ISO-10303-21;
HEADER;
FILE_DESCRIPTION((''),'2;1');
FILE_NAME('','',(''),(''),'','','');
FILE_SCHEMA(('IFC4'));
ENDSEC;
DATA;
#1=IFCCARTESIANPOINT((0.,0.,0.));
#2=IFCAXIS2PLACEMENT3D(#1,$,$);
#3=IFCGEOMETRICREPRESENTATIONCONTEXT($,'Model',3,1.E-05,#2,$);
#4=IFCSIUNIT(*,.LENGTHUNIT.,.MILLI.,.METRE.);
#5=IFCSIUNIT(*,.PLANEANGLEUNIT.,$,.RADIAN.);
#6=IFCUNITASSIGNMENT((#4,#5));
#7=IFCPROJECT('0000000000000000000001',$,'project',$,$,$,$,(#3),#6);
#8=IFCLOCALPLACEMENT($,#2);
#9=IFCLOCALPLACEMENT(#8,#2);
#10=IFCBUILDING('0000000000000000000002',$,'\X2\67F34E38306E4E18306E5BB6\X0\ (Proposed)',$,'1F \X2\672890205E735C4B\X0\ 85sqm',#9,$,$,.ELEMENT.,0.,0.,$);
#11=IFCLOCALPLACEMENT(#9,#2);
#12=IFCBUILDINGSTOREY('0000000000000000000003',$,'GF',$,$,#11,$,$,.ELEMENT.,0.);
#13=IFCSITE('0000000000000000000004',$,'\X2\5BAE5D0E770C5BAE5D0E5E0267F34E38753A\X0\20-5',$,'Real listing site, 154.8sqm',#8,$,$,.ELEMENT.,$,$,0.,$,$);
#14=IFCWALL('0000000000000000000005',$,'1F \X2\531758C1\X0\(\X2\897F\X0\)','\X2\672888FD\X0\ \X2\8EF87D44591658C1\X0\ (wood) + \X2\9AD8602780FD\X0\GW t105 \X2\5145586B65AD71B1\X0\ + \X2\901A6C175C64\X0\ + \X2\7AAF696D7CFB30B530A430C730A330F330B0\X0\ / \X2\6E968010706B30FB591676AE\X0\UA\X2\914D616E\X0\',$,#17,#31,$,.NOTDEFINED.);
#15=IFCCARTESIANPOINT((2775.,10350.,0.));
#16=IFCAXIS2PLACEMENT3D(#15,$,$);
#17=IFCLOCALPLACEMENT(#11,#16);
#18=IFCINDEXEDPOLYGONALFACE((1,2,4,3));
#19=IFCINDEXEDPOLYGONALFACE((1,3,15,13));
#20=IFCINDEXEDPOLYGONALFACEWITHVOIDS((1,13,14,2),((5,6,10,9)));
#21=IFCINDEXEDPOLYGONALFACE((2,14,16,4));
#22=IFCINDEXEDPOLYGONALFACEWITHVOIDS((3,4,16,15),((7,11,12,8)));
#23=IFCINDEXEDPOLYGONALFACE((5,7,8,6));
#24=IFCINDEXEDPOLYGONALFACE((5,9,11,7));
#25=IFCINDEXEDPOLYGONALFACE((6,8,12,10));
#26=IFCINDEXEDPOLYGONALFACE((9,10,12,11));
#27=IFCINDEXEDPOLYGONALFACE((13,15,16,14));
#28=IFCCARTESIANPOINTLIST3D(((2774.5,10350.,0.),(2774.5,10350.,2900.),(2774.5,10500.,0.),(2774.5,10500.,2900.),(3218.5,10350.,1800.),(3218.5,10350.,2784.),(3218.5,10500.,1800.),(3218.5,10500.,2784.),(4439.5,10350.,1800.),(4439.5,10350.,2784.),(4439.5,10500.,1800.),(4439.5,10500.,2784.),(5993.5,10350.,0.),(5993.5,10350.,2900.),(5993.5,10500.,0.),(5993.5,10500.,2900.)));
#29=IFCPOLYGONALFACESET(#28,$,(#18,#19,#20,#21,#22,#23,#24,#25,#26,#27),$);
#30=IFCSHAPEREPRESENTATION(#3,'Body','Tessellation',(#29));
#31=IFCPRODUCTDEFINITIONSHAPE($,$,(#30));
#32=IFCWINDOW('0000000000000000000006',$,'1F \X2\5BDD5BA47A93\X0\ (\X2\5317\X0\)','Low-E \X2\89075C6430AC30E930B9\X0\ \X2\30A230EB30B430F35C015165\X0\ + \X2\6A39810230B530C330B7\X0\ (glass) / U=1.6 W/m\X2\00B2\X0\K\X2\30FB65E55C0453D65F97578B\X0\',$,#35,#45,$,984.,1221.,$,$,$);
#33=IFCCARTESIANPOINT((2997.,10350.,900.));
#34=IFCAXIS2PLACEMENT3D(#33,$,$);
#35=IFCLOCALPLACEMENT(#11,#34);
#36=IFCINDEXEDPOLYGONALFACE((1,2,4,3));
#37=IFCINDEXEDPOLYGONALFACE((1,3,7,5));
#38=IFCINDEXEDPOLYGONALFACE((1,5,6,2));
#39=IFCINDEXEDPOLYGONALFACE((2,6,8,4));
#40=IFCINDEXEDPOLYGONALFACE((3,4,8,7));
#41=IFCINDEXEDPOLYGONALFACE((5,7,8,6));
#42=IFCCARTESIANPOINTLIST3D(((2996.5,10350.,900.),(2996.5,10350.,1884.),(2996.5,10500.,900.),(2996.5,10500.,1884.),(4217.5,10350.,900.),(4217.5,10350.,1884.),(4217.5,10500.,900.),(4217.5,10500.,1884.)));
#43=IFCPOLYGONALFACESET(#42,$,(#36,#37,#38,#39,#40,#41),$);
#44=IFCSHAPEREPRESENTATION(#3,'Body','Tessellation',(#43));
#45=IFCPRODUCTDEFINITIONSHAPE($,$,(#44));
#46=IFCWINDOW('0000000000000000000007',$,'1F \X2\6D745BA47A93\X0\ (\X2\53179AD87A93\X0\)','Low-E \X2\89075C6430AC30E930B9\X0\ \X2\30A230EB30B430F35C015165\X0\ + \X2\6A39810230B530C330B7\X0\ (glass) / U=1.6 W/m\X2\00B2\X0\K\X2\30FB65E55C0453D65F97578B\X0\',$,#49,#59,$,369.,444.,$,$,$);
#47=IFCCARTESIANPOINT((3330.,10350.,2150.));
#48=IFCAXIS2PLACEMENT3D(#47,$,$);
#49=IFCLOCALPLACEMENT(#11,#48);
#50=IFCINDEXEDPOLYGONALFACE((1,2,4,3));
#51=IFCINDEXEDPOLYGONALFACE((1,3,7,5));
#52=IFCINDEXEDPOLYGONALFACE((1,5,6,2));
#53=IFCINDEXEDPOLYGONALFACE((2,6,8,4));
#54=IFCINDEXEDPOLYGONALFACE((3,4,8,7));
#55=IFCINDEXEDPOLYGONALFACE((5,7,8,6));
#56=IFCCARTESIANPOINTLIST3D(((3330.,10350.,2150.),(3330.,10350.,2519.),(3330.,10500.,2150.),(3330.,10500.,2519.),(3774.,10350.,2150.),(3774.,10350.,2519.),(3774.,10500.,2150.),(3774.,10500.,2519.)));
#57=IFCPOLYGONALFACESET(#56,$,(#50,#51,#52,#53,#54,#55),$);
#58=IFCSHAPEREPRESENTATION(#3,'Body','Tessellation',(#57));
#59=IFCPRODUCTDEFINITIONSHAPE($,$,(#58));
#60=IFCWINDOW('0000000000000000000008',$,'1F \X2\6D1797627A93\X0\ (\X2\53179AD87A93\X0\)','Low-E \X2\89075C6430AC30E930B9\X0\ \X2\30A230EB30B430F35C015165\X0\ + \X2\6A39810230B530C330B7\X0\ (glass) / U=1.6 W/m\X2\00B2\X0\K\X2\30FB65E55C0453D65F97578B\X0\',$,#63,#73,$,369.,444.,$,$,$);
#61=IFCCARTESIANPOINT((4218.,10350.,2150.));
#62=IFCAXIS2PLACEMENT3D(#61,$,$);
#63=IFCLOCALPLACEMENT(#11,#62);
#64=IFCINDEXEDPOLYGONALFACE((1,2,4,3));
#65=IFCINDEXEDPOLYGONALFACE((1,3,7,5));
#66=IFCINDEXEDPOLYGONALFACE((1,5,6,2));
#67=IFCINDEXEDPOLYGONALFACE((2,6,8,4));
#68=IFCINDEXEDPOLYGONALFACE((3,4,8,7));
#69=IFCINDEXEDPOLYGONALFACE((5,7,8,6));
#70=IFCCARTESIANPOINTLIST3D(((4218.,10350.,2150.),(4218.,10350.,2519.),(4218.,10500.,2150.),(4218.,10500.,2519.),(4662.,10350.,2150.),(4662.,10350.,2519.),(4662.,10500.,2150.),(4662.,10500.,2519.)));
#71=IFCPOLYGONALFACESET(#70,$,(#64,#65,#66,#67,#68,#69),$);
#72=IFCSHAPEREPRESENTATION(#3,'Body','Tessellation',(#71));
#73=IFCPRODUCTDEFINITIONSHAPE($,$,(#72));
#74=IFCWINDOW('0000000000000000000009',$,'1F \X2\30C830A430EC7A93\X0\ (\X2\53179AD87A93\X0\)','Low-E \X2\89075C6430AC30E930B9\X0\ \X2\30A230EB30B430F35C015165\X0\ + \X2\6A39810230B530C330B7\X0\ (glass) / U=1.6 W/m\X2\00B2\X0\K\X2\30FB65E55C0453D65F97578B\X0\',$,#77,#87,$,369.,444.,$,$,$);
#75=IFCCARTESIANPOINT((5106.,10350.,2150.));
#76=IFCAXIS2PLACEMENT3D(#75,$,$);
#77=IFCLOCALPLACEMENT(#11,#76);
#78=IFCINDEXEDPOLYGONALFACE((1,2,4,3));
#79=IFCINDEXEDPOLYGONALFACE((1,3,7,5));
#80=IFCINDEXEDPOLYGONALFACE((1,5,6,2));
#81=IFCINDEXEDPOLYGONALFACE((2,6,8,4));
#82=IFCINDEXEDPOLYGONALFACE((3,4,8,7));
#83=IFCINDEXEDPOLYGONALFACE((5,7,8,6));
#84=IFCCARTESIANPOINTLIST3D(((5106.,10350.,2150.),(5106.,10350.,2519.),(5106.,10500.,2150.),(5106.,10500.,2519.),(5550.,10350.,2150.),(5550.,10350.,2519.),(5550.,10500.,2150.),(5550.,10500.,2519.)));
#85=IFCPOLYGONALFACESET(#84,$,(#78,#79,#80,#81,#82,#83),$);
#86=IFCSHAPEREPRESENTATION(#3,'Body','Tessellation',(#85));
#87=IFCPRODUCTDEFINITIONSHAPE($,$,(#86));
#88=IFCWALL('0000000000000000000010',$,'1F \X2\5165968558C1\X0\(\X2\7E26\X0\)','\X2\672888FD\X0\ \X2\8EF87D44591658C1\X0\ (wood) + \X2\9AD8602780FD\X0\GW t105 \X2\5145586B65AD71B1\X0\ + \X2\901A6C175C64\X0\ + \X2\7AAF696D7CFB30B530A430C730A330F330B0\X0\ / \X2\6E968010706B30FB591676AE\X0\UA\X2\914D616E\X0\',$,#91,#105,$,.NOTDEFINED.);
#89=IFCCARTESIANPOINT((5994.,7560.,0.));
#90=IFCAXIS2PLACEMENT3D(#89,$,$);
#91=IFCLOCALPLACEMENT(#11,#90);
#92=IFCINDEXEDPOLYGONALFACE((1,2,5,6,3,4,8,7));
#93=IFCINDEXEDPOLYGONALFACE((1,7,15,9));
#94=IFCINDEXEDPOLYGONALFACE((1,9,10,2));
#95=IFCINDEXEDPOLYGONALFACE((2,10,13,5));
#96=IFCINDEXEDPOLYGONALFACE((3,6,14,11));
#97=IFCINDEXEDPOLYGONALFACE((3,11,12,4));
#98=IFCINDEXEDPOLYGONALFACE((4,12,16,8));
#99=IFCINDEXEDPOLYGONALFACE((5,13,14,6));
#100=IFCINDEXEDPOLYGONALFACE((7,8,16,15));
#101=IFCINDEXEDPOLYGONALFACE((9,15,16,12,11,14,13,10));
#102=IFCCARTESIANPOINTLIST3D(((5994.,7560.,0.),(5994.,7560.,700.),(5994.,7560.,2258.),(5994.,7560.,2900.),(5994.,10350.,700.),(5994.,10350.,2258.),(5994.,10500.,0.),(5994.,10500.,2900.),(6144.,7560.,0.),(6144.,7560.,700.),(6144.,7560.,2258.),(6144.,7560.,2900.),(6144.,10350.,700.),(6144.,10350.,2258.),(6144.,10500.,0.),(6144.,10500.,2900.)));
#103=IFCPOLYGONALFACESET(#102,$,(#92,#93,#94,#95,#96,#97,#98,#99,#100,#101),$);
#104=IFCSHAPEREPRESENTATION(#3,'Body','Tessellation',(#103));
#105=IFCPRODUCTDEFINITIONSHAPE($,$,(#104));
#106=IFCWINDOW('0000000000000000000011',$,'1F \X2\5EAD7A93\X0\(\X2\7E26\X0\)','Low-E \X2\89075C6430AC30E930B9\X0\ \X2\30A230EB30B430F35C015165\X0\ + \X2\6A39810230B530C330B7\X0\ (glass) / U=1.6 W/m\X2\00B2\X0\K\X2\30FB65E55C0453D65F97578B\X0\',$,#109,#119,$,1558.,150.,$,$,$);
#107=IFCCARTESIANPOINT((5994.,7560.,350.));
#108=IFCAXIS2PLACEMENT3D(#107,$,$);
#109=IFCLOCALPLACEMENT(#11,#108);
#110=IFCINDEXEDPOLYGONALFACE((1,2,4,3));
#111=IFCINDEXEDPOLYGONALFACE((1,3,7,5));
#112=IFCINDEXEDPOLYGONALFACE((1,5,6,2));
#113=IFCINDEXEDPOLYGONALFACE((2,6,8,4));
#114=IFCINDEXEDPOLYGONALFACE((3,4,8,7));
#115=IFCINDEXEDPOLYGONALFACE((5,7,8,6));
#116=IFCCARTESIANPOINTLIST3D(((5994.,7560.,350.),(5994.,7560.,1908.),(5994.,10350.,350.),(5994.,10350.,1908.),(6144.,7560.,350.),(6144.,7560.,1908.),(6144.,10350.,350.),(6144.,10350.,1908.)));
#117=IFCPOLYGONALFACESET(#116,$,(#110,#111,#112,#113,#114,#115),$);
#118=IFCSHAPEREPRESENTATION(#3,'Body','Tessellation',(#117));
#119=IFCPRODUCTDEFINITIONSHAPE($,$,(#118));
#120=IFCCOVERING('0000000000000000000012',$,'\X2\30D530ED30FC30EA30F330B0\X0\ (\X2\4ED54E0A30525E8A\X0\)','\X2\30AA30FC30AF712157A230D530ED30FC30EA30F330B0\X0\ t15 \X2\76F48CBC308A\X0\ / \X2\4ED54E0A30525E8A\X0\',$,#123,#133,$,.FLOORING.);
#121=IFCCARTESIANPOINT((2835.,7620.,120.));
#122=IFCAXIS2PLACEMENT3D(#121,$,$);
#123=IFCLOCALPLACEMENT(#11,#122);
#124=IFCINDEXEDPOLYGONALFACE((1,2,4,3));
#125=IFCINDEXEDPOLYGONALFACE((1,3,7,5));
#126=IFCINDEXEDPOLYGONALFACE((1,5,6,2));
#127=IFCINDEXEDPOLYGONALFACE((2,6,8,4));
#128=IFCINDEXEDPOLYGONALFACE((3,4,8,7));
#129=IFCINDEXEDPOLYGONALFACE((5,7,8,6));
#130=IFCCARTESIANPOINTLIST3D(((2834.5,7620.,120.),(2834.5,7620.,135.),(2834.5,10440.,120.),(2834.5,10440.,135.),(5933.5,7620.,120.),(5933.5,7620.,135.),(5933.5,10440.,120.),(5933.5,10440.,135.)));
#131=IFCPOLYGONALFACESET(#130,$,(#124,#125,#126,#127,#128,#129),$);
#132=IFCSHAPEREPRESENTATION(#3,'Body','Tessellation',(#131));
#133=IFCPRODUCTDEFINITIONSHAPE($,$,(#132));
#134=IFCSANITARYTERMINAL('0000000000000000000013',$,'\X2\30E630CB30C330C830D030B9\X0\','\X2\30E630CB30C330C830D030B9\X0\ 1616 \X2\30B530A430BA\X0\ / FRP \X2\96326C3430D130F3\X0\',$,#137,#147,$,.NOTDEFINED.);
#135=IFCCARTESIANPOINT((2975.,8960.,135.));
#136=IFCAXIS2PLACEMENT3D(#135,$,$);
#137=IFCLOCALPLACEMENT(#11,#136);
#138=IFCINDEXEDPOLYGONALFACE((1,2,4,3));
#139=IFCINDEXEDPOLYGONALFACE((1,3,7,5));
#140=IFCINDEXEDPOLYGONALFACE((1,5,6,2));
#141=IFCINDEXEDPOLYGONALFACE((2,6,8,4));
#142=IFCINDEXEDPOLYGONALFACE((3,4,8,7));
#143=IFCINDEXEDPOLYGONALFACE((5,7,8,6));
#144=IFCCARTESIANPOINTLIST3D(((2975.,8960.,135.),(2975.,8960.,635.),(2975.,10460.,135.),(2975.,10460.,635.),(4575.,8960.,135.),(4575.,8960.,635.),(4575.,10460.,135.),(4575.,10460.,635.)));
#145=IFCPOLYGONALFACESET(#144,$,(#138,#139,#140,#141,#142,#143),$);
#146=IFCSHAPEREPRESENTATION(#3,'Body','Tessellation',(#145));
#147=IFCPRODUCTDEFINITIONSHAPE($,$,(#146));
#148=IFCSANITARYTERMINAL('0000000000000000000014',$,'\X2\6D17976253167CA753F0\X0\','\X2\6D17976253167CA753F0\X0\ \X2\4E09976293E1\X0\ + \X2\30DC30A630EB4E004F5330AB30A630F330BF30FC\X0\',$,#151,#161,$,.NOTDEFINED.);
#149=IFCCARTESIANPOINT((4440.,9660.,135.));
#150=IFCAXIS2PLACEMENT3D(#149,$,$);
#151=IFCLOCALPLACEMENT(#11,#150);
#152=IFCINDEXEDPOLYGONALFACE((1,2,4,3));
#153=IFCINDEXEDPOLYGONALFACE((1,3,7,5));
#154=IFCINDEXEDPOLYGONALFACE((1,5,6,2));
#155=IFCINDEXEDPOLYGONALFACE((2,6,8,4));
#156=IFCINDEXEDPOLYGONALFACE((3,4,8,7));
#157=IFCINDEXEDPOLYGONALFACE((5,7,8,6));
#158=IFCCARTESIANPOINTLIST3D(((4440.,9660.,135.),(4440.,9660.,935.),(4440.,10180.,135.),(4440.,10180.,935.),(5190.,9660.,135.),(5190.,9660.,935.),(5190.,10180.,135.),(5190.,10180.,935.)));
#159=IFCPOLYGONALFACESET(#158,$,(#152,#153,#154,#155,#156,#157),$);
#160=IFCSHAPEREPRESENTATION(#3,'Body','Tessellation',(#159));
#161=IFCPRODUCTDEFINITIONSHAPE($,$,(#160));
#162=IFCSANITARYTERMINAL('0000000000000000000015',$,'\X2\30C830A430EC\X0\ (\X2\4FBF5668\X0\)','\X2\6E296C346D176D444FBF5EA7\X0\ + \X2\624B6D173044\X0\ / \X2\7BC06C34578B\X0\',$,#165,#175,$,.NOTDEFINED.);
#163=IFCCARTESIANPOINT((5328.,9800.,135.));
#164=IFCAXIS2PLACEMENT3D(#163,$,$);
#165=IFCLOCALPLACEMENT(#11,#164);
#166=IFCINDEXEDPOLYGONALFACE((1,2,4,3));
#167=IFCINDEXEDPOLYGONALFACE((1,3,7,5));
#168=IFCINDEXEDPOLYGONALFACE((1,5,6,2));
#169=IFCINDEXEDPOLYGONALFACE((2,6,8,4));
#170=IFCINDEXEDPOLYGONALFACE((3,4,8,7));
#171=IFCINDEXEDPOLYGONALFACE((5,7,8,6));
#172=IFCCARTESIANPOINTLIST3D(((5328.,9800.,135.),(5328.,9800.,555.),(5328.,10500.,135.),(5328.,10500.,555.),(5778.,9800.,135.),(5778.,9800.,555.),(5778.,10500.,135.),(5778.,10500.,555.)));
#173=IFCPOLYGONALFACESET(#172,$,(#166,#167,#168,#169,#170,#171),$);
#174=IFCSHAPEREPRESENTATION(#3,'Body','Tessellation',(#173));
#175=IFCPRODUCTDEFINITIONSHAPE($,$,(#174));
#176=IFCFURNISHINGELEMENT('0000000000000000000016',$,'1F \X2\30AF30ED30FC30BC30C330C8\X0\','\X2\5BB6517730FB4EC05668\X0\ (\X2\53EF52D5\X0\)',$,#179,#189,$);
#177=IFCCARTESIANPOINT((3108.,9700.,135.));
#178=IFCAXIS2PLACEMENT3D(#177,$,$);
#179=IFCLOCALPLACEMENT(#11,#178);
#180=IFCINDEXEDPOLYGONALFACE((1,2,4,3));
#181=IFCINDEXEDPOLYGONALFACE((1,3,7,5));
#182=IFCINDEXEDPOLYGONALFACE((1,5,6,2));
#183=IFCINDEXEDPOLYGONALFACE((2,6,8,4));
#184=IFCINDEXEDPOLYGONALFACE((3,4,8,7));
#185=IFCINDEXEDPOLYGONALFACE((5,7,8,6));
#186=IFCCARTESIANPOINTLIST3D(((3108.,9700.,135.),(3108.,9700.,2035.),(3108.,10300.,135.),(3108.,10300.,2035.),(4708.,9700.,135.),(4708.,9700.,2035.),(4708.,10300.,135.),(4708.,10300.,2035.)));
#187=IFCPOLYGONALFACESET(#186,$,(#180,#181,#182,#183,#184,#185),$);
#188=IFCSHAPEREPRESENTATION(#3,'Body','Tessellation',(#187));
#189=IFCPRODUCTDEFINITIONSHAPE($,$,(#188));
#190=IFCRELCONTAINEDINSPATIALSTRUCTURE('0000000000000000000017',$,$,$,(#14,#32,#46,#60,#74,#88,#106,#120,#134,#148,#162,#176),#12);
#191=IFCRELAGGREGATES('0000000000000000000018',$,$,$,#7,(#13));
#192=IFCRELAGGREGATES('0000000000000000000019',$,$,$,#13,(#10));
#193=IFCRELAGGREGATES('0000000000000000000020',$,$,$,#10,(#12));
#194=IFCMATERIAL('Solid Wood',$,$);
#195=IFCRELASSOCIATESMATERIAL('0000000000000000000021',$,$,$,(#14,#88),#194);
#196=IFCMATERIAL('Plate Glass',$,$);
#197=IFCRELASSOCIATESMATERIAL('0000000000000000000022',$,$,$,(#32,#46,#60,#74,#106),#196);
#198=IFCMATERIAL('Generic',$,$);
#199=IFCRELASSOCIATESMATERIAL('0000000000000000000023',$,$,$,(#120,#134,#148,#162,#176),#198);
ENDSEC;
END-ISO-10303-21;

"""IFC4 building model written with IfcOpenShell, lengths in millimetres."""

from ifc_helpers import new_model, si_unit, frame, frame_2d, origin, place, context, project, spatial, rectangle, extrude, material, element, fill, save


model = new_model("IFC4")

# Units and contexts
model_context = context("Model", 3, precision=1e-05, world=origin())
ifc_project = project(units=[si_unit("LENGTHUNIT", "METRE", prefix="MILLI"), si_unit("PLANEANGLEUNIT", "RADIAN")], contexts=[model_context])

# Site, building, storey
site_placement = place(None, origin())
site = spatial("IfcSite", under=ifc_project, at=site_placement, Name="宮崎県宮崎市柳丸町20-5", ObjectType="Real listing site, 154.8sqm", CompositionType="ELEMENT", RefElevation=0.0)
building_placement = place(site_placement, origin())
building = spatial("IfcBuilding", under=site, at=building_placement, Name="柳丸の丘の家 (Proposed)", ObjectType="1F 木造平屋 85sqm", CompositionType="ELEMENT", ElevationOfRefHeight=0.0, ElevationOfTerrain=0.0)
storey_placement = place(building_placement, origin())
storey = spatial("IfcBuildingStorey", under=building, at=storey_placement, Name="GF", CompositionType="ELEMENT", Elevation=0.0)

# Shared definitions
ifc_material_1 = material(Name="Solid Wood")

# Wall, openings, windows
wall_1_placement = place(storey_placement, frame((2775.0, 10350.0, 0.0)))
wall_1 = element("IfcWall", 1, at=wall_1_placement, inside=storey, material=ifc_material_1, Name="1F 北壁(西)", Description="木製 軸組外壁 (wood) + 高性能GW t105 充填断熱 + 通気層 + 窯業系サイディング / 準耐火・外皮UA配慮", PredefinedType="NOTDEFINED", context=model_context, shape_type="SweptSolid", body=[
    extrude(rectangle(XDim=3219.0, YDim=150.0, at=frame_2d((1609.0, 75.0))), frame((2775.0, 10350.0, 0.0)), (0.0, 0.0, 1.0), 2900.0),
])
opening_1_placement = place(storey_placement, frame((2997.0, 10350.0, 900.0)))
opening_1 = element("IfcOpeningElement", 2, at=opening_1_placement, cuts=wall_1, PredefinedType="NOTDEFINED", context=model_context, shape_type="SweptSolid", body=[
    extrude(rectangle(XDim=1221.0, YDim=150.0, at=frame_2d((610.0, 75.0))), frame((2997.0, 10350.0, 900.0)), (0.0, 0.0, 1.0), 984.0),
])
opening_2_placement = place(storey_placement, frame((3330.0, 10350.0, 2150.0)))
opening_2 = element("IfcOpeningElement", 3, at=opening_2_placement, cuts=wall_1, PredefinedType="NOTDEFINED", context=model_context, shape_type="SweptSolid", body=[
    extrude(rectangle(XDim=444.0, YDim=150.0, at=frame_2d((222.0, 75.0))), frame((3330.0, 10350.0, 2150.0)), (0.0, 0.0, 1.0), 369.0),
])
opening_3_placement = place(storey_placement, frame((4218.0, 10350.0, 2150.0)))
opening_3 = element("IfcOpeningElement", 4, at=opening_3_placement, cuts=wall_1, PredefinedType="NOTDEFINED", context=model_context, shape_type="SweptSolid", body=[
    extrude(rectangle(XDim=444.0, YDim=150.0, at=frame_2d((222.0, 75.0))), frame((4218.0, 10350.0, 2150.0)), (0.0, 0.0, 1.0), 369.0),
])
opening_4_placement = place(storey_placement, frame((5106.0, 10350.0, 2150.0)))
opening_4 = element("IfcOpeningElement", 5, at=opening_4_placement, cuts=wall_1, PredefinedType="NOTDEFINED", context=model_context, shape_type="SweptSolid", body=[
    extrude(rectangle(XDim=444.0, YDim=150.0, at=frame_2d((222.0, 75.0))), frame((5106.0, 10350.0, 2150.0)), (0.0, 0.0, 1.0), 369.0),
])
ifc_material_2 = material(Name="Plate Glass")
window_1_placement = place(storey_placement, frame((2997.0, 10350.0, 900.0)))
window_1 = element("IfcWindow", 6, at=window_1_placement, inside=storey, material=ifc_material_2, Name="1F 寝室窓 (北)", Description="Low-E 複層ガラス アルゴン封入 + 樹脂サッシ (glass) / U=1.6 W/m²K・日射取得型", OverallHeight=984.0, OverallWidth=1221.0, context=model_context, shape_type="SweptSolid", body=[
    extrude(rectangle(XDim=1221.0, YDim=150.0, at=frame_2d((610.0, 75.0))), frame((2997.0, 10350.0, 900.0)), (0.0, 0.0, 1.0), 984.0),
])
fill(opening_1, window_1)
window_2_placement = place(storey_placement, frame((3330.0, 10350.0, 2150.0)))
window_2 = element("IfcWindow", 7, at=window_2_placement, inside=storey, material=ifc_material_2, Name="1F 浴室窓 (北高窓)", Description="Low-E 複層ガラス アルゴン封入 + 樹脂サッシ (glass) / U=1.6 W/m²K・日射取得型", OverallHeight=369.0, OverallWidth=444.0, context=model_context, shape_type="SweptSolid", body=[
    extrude(rectangle(XDim=444.0, YDim=150.0, at=frame_2d((222.0, 75.0))), frame((3330.0, 10350.0, 2150.0)), (0.0, 0.0, 1.0), 369.0),
])
fill(opening_2, window_2)
window_3_placement = place(storey_placement, frame((4218.0, 10350.0, 2150.0)))
window_3 = element("IfcWindow", 8, at=window_3_placement, inside=storey, material=ifc_material_2, Name="1F 洗面窓 (北高窓)", Description="Low-E 複層ガラス アルゴン封入 + 樹脂サッシ (glass) / U=1.6 W/m²K・日射取得型", OverallHeight=369.0, OverallWidth=444.0, context=model_context, shape_type="SweptSolid", body=[
    extrude(rectangle(XDim=444.0, YDim=150.0, at=frame_2d((222.0, 75.0))), frame((4218.0, 10350.0, 2150.0)), (0.0, 0.0, 1.0), 369.0),
])
fill(opening_3, window_3)
window_4_placement = place(storey_placement, frame((5106.0, 10350.0, 2150.0)))
window_4 = element("IfcWindow", 9, at=window_4_placement, inside=storey, material=ifc_material_2, Name="1F トイレ窓 (北高窓)", Description="Low-E 複層ガラス アルゴン封入 + 樹脂サッシ (glass) / U=1.6 W/m²K・日射取得型", OverallHeight=369.0, OverallWidth=444.0, context=model_context, shape_type="SweptSolid", body=[
    extrude(rectangle(XDim=444.0, YDim=150.0, at=frame_2d((222.0, 75.0))), frame((5106.0, 10350.0, 2150.0)), (0.0, 0.0, 1.0), 369.0),
])
fill(opening_4, window_4)

# Wall, opening, window
wall_2_placement = place(storey_placement, frame((5994.0, 7560.0, 0.0)))
wall_2 = element("IfcWall", 10, at=wall_2_placement, inside=storey, material=ifc_material_1, Name="1F 入隅壁(縦)", Description="木製 軸組外壁 (wood) + 高性能GW t105 充填断熱 + 通気層 + 窯業系サイディング / 準耐火・外皮UA配慮", PredefinedType="NOTDEFINED", context=model_context, shape_type="SweptSolid", body=[
    extrude(rectangle(XDim=150.0, YDim=2940.0, at=frame_2d((75.0, 1470.0))), frame((5994.0, 7560.0, 0.0)), (0.0, 0.0, 1.0), 2900.0),
])
opening_5_placement = place(storey_placement, frame((5994.0, 7560.0, 350.0)))
opening_5 = element("IfcOpeningElement", 11, at=opening_5_placement, cuts=wall_2, PredefinedType="NOTDEFINED", context=model_context, shape_type="SweptSolid", body=[
    extrude(rectangle(XDim=150.0, YDim=2790.0, at=frame_2d((75.0, 1395.0))), frame((5994.0, 7560.0, 350.0)), (0.0, 0.0, 1.0), 1558.0),
])
window_5_placement = place(storey_placement, frame((5994.0, 7560.0, 350.0)))
window_5 = element("IfcWindow", 12, at=window_5_placement, inside=storey, material=ifc_material_2, Name="1F 庭窓(縦)", Description="Low-E 複層ガラス アルゴン封入 + 樹脂サッシ (glass) / U=1.6 W/m²K・日射取得型", OverallHeight=1558.0, OverallWidth=150.0, context=model_context, shape_type="SweptSolid", body=[
    extrude(rectangle(XDim=150.0, YDim=2790.0, at=frame_2d((75.0, 1395.0))), frame((5994.0, 7560.0, 350.0)), (0.0, 0.0, 1.0), 1558.0),
])
fill(opening_5, window_5)

# Covering
ifc_material_3 = material(Name="Generic")
covering_placement = place(storey_placement, frame((2835.0, 7620.0, 120.0)))
element("IfcCovering", 13, at=covering_placement, inside=storey, material=ifc_material_3, Name="フローリング (仕上げ床)", Description="オーク無垢フローリング t15 直貼り / 仕上げ床", PredefinedType="FLOORING", context=model_context, shape_type="SweptSolid", body=[
    extrude(rectangle(XDim=3099.0, YDim=2820.0, at=frame_2d((1549.0, 1410.0))), frame((2835.0, 7620.0, 120.0)), (0.0, 0.0, 1.0), 15.0),
])

# Sanitary terminals
sanitary_terminal_1_placement = place(storey_placement, frame((2975.0, 8960.0, 135.0)))
element("IfcSanitaryTerminal", 14, at=sanitary_terminal_1_placement, inside=storey, material=ifc_material_3, Name="ユニットバス", Description="ユニットバス 1616 サイズ / FRP 防水パン", PredefinedType="NOTDEFINED", context=model_context, shape_type="SweptSolid", body=[
    extrude(rectangle(XDim=1600.0, YDim=1500.0, at=frame_2d((800.0, 750.0))), frame((2975.0, 8960.0, 135.0)), (0.0, 0.0, 1.0), 500.0),
])
sanitary_terminal_2_placement = place(storey_placement, frame((4440.0, 9660.0, 135.0)))
element("IfcSanitaryTerminal", 15, at=sanitary_terminal_2_placement, inside=storey, material=ifc_material_3, Name="洗面化粧台", Description="洗面化粧台 三面鏡 + ボウル一体カウンター", PredefinedType="NOTDEFINED", context=model_context, shape_type="SweptSolid", body=[
    extrude(rectangle(XDim=750.0, YDim=520.0, at=frame_2d((375.0, 260.0))), frame((4440.0, 9660.0, 135.0)), (0.0, 0.0, 1.0), 800.0),
])
sanitary_terminal_3_placement = place(storey_placement, frame((5328.0, 9800.0, 135.0)))
element("IfcSanitaryTerminal", 16, at=sanitary_terminal_3_placement, inside=storey, material=ifc_material_3, Name="トイレ (便器)", Description="温水洗浄便座 + 手洗い / 節水型", PredefinedType="NOTDEFINED", context=model_context, shape_type="SweptSolid", body=[
    extrude(rectangle(XDim=450.0, YDim=700.0, at=frame_2d((225.0, 350.0))), frame((5328.0, 9800.0, 135.0)), (0.0, 0.0, 1.0), 420.0),
])

# Furnishing element
furnishing_1_placement = place(storey_placement, frame((3108.0, 9700.0, 135.0)))
element("IfcFurnishingElement", 17, at=furnishing_1_placement, inside=storey, material=ifc_material_3, Name="1F クローゼット", Description="家具・什器 (可動)", context=model_context, shape_type="SweptSolid", body=[
    extrude(rectangle(XDim=1600.0, YDim=600.0, at=frame_2d((800.0, 300.0))), frame((3108.0, 9700.0, 135.0)), (0.0, 0.0, 1.0), 1900.0),
])

save(model, "model.ifc")
